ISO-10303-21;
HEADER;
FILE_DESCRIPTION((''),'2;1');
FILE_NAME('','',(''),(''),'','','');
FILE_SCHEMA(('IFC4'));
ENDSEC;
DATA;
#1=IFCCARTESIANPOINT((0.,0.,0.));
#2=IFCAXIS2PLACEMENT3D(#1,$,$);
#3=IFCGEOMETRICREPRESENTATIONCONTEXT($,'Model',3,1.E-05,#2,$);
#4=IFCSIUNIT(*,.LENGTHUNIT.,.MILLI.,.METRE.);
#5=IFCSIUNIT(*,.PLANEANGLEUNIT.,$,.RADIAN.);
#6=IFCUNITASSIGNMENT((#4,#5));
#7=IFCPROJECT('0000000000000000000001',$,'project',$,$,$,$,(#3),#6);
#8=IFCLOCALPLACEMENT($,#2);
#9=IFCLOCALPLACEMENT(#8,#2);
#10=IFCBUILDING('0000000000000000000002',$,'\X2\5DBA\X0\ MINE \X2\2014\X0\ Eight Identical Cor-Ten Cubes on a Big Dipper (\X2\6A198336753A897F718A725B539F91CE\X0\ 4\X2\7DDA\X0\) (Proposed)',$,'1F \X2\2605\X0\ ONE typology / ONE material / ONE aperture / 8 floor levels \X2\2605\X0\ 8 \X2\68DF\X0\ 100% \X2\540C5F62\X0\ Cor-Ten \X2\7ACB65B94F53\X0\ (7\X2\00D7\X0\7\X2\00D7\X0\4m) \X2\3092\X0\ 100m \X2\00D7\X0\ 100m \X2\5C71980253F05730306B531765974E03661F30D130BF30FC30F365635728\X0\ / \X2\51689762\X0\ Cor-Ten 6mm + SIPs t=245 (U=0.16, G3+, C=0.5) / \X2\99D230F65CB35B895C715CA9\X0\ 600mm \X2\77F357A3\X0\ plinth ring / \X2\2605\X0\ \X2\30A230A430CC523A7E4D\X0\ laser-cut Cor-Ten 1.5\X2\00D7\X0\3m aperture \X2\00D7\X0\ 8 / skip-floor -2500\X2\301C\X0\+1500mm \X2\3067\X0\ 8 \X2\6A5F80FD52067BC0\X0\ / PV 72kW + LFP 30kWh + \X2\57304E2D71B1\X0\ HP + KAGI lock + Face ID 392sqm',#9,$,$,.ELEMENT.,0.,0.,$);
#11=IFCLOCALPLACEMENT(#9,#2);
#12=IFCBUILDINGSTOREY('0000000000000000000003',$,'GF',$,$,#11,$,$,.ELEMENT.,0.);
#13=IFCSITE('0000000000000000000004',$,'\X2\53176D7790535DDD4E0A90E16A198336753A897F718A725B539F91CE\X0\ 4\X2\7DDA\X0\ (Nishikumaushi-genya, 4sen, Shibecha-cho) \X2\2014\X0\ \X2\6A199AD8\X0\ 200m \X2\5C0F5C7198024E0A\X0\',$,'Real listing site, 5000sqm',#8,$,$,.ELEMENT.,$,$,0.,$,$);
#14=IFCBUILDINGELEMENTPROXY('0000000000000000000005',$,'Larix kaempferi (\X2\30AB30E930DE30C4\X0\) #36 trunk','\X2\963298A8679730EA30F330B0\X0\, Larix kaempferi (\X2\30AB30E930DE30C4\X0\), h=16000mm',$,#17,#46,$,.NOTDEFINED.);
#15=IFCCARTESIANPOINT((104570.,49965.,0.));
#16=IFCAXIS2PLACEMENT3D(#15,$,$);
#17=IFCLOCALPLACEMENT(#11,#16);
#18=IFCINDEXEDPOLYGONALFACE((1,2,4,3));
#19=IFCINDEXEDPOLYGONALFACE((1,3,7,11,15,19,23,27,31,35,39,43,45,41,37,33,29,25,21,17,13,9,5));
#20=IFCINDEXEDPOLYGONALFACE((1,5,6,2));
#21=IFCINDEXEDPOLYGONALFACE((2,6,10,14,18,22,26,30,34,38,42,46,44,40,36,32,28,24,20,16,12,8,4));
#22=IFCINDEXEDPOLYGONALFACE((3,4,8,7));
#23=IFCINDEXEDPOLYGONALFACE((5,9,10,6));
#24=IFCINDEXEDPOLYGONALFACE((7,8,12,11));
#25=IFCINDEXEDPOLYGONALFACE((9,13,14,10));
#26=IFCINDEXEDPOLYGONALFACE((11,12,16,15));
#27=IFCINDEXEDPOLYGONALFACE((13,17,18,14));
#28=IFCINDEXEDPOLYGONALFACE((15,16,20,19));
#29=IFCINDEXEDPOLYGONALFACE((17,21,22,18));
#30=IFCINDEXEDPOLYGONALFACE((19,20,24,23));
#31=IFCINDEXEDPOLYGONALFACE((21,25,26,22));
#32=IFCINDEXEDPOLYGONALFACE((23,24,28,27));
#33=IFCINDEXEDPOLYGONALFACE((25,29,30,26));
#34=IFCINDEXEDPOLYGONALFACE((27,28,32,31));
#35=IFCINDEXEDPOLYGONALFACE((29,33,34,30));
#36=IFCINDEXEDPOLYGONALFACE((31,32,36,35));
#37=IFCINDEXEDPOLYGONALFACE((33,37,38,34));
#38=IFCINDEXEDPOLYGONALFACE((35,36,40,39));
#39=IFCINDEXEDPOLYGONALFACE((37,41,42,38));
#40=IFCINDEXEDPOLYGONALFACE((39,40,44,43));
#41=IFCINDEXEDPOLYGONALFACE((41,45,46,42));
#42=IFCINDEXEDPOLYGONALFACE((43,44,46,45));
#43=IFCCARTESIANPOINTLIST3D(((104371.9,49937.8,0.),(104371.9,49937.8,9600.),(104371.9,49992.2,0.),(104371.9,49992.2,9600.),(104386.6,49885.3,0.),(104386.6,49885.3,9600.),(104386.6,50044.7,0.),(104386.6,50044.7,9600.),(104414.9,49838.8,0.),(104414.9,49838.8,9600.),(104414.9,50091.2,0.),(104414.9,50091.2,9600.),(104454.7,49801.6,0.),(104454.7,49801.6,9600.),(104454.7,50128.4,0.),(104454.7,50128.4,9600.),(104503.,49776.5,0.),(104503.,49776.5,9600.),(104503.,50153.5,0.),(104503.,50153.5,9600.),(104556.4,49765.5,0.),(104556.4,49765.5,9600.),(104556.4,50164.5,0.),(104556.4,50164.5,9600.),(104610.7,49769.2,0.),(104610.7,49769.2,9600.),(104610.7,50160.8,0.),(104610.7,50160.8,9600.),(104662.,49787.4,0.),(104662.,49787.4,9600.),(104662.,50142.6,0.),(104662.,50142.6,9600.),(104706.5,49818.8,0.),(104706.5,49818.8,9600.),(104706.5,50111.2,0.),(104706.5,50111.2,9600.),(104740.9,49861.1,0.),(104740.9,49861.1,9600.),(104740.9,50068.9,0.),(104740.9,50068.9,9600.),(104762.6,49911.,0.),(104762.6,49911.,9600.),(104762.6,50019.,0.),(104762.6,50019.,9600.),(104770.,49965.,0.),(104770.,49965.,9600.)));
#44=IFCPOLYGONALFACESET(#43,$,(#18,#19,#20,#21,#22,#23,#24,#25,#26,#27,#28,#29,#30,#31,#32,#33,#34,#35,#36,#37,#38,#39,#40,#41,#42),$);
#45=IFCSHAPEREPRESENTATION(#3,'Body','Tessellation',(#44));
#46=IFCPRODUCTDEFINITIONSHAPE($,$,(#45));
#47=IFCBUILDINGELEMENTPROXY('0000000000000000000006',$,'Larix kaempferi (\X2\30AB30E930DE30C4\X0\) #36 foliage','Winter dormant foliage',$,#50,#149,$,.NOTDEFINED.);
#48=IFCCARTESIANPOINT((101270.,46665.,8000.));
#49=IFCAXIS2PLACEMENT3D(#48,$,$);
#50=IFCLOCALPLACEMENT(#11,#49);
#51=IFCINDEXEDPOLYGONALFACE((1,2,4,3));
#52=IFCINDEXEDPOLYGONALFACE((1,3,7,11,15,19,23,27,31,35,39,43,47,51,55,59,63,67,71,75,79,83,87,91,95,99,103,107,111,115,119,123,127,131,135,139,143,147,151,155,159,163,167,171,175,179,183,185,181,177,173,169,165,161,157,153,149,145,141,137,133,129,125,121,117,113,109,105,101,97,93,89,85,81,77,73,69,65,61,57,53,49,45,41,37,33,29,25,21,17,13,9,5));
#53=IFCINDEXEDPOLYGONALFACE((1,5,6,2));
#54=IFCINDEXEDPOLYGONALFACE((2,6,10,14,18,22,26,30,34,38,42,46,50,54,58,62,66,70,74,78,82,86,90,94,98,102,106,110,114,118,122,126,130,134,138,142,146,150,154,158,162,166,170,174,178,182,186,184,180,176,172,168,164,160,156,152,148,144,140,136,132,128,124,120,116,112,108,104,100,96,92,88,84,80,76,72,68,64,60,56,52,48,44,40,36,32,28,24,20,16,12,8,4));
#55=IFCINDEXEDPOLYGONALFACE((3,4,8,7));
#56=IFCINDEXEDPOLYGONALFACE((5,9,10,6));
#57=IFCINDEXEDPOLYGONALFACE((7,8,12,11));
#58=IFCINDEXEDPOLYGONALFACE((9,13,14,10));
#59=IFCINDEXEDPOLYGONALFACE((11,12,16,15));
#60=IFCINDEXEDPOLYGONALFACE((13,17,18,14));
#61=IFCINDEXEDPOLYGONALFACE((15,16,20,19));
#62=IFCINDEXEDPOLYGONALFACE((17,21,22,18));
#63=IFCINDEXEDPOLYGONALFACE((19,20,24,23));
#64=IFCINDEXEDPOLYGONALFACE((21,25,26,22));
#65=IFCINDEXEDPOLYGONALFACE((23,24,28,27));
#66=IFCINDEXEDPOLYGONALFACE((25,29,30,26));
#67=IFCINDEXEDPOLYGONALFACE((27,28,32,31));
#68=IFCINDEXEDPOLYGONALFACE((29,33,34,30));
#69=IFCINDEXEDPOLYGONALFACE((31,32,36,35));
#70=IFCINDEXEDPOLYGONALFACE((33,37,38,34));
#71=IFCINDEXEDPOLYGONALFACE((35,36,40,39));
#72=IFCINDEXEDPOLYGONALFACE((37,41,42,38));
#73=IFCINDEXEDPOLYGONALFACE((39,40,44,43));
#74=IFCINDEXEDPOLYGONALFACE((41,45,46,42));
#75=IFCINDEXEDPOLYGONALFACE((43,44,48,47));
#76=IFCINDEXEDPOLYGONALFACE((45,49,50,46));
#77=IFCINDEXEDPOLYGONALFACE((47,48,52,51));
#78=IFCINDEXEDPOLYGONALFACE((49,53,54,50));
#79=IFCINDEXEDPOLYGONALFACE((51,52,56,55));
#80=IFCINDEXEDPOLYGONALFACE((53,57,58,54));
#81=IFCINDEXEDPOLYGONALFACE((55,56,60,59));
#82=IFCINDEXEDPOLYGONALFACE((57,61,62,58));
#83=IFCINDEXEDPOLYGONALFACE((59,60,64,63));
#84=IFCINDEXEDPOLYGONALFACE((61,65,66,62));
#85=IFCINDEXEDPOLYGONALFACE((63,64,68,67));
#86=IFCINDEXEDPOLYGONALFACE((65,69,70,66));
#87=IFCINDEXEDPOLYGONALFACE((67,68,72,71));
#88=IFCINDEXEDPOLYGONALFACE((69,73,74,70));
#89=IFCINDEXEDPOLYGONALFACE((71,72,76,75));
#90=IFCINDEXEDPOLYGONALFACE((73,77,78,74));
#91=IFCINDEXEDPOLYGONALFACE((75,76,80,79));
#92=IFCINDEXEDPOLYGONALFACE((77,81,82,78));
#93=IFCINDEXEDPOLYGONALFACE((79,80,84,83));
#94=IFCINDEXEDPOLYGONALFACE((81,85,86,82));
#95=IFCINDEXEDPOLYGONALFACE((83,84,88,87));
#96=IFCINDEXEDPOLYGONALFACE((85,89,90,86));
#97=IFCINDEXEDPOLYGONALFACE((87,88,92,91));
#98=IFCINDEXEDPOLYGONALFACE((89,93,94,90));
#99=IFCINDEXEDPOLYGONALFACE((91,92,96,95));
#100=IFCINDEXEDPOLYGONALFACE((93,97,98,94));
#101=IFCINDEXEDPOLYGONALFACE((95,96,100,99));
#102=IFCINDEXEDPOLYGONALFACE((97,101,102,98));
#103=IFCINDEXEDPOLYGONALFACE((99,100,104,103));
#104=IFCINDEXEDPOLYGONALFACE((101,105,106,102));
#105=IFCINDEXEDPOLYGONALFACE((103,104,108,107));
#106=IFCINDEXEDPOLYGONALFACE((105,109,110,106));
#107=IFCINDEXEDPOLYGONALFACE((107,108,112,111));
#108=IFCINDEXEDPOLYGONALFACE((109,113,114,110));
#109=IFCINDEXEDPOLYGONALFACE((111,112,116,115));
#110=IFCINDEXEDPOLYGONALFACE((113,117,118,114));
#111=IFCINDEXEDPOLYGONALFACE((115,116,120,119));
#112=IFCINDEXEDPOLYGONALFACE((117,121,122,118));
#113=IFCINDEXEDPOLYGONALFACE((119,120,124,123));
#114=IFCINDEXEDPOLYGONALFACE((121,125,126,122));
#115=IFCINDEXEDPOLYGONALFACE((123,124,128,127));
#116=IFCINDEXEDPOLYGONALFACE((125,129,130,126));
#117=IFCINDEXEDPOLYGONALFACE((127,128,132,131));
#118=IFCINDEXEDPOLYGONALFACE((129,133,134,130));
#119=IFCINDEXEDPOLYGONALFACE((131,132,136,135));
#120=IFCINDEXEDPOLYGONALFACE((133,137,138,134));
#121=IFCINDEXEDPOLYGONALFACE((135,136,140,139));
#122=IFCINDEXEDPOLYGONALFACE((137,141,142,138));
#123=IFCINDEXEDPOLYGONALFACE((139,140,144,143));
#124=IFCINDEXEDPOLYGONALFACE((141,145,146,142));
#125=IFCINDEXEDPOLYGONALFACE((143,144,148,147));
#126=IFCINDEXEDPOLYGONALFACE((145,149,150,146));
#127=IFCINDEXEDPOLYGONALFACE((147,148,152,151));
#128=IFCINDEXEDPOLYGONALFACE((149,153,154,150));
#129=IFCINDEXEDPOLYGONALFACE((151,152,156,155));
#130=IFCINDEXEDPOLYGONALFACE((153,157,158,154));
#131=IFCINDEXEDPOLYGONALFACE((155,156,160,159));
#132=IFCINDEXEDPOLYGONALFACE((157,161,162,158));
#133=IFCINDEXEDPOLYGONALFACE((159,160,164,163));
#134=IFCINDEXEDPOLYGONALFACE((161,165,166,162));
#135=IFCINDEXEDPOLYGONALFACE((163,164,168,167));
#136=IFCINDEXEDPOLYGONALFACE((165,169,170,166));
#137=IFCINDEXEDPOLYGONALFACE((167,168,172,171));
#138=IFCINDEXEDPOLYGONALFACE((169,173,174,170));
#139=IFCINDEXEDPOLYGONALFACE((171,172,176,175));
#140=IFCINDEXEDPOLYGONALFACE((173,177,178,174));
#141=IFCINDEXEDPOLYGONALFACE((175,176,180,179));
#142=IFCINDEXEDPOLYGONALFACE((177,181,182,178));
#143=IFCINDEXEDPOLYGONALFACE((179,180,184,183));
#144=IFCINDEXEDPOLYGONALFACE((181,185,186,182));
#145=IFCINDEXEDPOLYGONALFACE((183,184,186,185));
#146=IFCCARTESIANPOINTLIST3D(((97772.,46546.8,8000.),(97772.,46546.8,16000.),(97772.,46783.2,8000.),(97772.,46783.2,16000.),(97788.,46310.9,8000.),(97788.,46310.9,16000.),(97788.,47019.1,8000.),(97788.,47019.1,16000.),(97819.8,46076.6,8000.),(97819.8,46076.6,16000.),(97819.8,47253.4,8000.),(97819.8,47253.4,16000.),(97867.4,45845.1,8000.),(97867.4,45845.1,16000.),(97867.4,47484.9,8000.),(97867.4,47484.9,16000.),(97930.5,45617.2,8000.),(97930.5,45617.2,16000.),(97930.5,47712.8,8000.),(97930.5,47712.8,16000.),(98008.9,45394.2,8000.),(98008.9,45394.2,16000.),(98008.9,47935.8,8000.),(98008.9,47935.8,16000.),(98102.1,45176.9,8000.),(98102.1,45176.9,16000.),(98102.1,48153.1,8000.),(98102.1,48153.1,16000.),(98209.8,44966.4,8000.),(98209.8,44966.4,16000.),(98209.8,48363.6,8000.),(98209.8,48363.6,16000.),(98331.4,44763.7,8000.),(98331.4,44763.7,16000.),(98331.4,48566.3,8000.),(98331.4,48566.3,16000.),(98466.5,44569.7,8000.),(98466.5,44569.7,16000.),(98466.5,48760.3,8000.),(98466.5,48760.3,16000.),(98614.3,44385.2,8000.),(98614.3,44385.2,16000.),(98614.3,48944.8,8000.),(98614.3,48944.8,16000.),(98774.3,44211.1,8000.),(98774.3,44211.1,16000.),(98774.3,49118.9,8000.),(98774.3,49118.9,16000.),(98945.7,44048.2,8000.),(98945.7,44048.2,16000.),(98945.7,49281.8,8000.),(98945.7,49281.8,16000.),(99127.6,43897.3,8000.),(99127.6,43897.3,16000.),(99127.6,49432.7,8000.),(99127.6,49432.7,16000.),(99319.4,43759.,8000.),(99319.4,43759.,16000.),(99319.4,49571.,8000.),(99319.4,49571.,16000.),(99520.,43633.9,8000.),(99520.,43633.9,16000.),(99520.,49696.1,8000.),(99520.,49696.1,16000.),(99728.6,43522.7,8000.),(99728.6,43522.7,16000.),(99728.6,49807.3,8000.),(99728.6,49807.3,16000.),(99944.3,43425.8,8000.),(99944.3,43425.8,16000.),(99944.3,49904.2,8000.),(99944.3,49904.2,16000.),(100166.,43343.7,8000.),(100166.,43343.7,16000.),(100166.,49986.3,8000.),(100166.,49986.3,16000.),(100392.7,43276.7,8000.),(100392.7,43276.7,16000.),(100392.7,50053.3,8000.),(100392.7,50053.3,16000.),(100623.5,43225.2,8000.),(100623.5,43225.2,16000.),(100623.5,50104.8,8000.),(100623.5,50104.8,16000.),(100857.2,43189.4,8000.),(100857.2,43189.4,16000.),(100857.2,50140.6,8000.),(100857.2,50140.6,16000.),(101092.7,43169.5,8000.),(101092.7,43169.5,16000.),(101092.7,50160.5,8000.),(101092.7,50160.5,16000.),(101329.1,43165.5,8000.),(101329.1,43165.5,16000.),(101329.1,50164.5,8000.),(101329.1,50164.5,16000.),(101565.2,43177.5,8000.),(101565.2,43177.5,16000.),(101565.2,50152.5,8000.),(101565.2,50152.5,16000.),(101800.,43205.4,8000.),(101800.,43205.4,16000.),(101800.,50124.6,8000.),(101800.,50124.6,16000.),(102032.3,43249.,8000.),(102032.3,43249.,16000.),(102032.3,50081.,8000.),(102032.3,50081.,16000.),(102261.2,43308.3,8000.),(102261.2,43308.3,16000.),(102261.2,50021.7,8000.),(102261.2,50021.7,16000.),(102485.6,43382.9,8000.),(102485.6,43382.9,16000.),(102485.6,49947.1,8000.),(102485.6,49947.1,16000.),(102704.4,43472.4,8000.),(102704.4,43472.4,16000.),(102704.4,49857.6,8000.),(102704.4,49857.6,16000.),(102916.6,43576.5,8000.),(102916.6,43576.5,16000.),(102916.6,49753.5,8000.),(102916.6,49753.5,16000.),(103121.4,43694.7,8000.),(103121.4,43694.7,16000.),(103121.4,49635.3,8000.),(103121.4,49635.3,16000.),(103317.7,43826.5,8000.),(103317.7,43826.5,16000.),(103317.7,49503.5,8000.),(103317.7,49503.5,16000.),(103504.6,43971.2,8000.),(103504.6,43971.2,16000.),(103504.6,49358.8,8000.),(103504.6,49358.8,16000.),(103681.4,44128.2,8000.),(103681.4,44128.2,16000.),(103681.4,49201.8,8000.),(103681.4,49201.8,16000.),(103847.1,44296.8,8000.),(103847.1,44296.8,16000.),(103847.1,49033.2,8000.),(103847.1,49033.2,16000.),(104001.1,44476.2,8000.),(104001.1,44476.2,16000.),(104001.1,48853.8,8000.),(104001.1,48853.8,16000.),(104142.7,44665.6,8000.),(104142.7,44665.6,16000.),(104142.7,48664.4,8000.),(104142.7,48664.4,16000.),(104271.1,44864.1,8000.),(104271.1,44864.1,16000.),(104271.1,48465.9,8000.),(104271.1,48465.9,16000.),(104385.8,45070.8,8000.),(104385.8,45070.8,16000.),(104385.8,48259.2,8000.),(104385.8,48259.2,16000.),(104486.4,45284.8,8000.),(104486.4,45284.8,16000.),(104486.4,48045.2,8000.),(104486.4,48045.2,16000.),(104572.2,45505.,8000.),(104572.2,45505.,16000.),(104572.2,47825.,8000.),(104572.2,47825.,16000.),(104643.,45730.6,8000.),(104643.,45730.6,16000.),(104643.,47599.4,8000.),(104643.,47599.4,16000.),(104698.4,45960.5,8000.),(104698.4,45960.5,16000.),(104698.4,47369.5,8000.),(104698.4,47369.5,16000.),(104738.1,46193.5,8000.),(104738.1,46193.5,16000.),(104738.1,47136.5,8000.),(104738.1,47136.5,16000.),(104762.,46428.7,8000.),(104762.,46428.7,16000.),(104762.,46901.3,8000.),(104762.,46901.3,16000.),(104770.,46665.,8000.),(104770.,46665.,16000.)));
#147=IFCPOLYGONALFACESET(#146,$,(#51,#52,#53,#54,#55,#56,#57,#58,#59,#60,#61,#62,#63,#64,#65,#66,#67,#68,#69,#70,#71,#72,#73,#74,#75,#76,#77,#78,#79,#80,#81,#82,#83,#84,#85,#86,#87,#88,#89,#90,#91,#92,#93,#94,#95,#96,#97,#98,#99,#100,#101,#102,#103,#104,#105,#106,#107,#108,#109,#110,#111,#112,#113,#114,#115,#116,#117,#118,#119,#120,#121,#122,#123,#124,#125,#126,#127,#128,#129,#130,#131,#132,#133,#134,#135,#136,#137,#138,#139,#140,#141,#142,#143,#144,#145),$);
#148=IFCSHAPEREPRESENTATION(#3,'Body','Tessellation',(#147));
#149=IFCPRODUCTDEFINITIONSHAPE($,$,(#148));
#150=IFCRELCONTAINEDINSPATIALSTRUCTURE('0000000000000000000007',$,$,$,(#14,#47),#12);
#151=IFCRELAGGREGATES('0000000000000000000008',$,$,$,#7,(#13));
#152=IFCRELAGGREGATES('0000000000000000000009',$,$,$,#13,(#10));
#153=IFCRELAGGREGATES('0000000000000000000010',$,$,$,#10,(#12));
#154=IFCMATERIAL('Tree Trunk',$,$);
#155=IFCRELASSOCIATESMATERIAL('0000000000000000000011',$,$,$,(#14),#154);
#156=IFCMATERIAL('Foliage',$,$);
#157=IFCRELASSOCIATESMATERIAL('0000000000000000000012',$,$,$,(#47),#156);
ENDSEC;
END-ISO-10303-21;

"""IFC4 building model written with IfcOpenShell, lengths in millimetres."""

from ifc_helpers import new_model, si_unit, frame, origin, origin_2d, place, context, project, spatial, circle, extrude, material, element, save


model = new_model("IFC4")

# Units and contexts
model_context = context("Model", 3, precision=1e-05, world=origin())
ifc_project = project(units=[si_unit("LENGTHUNIT", "METRE", prefix="MILLI"), si_unit("PLANEANGLEUNIT", "RADIAN")], contexts=[model_context])

# Site, building, storey
site_placement = place(None, origin())
site = spatial("IfcSite", under=ifc_project, at=site_placement, Name="北海道川上郡標茶町西熊牛原野 4線 (Nishikumaushi-genya, 4sen, Shibecha-cho) — 標高 200m 小山頂上", ObjectType="Real listing site, 5000sqm", CompositionType="ELEMENT", RefElevation=0.0)
building_placement = place(site_placement, origin())
building = spatial("IfcBuilding", under=site, at=building_placement, Name="嶺 MINE — Eight Identical Cor-Ten Cubes on a Big Dipper (標茶町西熊牛原野 4線) (Proposed)", ObjectType="1F ★ ONE typology / ONE material / ONE aperture / 8 floor levels ★ 8 棟 100% 同形 Cor-Ten 立方体 (7×7×4m) を 100m × 100m 山頂台地に北斗七星パターン散在 / 全面 Cor-Ten 6mm + SIPs t=245 (U=0.16, G3+, C=0.5) / 駒ヶ岳安山岩 600mm 石垣 plinth ring / ★ アイヌ刺繍 laser-cut Cor-Ten 1.5×3m aperture × 8 / skip-floor -2500〜+1500mm で 8 機能分節 / PV 72kW + LFP 30kWh + 地中熱 HP + KAGI lock + Face ID 392sqm", CompositionType="ELEMENT", ElevationOfRefHeight=0.0, ElevationOfTerrain=0.0)
storey_placement = place(building_placement, origin())
storey = spatial("IfcBuildingStorey", under=building, at=storey_placement, Name="GF", CompositionType="ELEMENT", Elevation=0.0)

# Building element proxies
ifc_material_1 = material(Name="Tree Trunk")
ifc_material_2 = material(Name="Foliage")
proxy_1_placement = place(storey_placement, frame((104570.0, 49965.0, 0.0)))
element("IfcBuildingElementProxy", 1, at=proxy_1_placement, inside=storey, material=ifc_material_1, Name="Larix kaempferi (カラマツ) #36 trunk", Description="防風林リング, Larix kaempferi (カラマツ), h=16000mm", PredefinedType="NOTDEFINED", context=model_context, shape_type="SweptSolid", body=[
    extrude(circle(Radius=200.0, at=origin_2d()), frame((104570.0, 49965.0, 0.0)), (0.0, 0.0, 1.0), 9600.0),
])
proxy_2_placement = place(storey_placement, frame((101270.0, 46665.0, 8000.0)))
element("IfcBuildingElementProxy", 2, at=proxy_2_placement, inside=storey, material=ifc_material_2, Name="Larix kaempferi (カラマツ) #36 foliage", Description="Winter dormant foliage", PredefinedType="NOTDEFINED", context=model_context, shape_type="SweptSolid", body=[
    extrude(circle(Radius=3500.0, at=origin_2d()), frame((101270.0, 46665.0, 8000.0)), (0.0, 0.0, 1.0), 8000.0),
])

save(model, "model.ifc")
